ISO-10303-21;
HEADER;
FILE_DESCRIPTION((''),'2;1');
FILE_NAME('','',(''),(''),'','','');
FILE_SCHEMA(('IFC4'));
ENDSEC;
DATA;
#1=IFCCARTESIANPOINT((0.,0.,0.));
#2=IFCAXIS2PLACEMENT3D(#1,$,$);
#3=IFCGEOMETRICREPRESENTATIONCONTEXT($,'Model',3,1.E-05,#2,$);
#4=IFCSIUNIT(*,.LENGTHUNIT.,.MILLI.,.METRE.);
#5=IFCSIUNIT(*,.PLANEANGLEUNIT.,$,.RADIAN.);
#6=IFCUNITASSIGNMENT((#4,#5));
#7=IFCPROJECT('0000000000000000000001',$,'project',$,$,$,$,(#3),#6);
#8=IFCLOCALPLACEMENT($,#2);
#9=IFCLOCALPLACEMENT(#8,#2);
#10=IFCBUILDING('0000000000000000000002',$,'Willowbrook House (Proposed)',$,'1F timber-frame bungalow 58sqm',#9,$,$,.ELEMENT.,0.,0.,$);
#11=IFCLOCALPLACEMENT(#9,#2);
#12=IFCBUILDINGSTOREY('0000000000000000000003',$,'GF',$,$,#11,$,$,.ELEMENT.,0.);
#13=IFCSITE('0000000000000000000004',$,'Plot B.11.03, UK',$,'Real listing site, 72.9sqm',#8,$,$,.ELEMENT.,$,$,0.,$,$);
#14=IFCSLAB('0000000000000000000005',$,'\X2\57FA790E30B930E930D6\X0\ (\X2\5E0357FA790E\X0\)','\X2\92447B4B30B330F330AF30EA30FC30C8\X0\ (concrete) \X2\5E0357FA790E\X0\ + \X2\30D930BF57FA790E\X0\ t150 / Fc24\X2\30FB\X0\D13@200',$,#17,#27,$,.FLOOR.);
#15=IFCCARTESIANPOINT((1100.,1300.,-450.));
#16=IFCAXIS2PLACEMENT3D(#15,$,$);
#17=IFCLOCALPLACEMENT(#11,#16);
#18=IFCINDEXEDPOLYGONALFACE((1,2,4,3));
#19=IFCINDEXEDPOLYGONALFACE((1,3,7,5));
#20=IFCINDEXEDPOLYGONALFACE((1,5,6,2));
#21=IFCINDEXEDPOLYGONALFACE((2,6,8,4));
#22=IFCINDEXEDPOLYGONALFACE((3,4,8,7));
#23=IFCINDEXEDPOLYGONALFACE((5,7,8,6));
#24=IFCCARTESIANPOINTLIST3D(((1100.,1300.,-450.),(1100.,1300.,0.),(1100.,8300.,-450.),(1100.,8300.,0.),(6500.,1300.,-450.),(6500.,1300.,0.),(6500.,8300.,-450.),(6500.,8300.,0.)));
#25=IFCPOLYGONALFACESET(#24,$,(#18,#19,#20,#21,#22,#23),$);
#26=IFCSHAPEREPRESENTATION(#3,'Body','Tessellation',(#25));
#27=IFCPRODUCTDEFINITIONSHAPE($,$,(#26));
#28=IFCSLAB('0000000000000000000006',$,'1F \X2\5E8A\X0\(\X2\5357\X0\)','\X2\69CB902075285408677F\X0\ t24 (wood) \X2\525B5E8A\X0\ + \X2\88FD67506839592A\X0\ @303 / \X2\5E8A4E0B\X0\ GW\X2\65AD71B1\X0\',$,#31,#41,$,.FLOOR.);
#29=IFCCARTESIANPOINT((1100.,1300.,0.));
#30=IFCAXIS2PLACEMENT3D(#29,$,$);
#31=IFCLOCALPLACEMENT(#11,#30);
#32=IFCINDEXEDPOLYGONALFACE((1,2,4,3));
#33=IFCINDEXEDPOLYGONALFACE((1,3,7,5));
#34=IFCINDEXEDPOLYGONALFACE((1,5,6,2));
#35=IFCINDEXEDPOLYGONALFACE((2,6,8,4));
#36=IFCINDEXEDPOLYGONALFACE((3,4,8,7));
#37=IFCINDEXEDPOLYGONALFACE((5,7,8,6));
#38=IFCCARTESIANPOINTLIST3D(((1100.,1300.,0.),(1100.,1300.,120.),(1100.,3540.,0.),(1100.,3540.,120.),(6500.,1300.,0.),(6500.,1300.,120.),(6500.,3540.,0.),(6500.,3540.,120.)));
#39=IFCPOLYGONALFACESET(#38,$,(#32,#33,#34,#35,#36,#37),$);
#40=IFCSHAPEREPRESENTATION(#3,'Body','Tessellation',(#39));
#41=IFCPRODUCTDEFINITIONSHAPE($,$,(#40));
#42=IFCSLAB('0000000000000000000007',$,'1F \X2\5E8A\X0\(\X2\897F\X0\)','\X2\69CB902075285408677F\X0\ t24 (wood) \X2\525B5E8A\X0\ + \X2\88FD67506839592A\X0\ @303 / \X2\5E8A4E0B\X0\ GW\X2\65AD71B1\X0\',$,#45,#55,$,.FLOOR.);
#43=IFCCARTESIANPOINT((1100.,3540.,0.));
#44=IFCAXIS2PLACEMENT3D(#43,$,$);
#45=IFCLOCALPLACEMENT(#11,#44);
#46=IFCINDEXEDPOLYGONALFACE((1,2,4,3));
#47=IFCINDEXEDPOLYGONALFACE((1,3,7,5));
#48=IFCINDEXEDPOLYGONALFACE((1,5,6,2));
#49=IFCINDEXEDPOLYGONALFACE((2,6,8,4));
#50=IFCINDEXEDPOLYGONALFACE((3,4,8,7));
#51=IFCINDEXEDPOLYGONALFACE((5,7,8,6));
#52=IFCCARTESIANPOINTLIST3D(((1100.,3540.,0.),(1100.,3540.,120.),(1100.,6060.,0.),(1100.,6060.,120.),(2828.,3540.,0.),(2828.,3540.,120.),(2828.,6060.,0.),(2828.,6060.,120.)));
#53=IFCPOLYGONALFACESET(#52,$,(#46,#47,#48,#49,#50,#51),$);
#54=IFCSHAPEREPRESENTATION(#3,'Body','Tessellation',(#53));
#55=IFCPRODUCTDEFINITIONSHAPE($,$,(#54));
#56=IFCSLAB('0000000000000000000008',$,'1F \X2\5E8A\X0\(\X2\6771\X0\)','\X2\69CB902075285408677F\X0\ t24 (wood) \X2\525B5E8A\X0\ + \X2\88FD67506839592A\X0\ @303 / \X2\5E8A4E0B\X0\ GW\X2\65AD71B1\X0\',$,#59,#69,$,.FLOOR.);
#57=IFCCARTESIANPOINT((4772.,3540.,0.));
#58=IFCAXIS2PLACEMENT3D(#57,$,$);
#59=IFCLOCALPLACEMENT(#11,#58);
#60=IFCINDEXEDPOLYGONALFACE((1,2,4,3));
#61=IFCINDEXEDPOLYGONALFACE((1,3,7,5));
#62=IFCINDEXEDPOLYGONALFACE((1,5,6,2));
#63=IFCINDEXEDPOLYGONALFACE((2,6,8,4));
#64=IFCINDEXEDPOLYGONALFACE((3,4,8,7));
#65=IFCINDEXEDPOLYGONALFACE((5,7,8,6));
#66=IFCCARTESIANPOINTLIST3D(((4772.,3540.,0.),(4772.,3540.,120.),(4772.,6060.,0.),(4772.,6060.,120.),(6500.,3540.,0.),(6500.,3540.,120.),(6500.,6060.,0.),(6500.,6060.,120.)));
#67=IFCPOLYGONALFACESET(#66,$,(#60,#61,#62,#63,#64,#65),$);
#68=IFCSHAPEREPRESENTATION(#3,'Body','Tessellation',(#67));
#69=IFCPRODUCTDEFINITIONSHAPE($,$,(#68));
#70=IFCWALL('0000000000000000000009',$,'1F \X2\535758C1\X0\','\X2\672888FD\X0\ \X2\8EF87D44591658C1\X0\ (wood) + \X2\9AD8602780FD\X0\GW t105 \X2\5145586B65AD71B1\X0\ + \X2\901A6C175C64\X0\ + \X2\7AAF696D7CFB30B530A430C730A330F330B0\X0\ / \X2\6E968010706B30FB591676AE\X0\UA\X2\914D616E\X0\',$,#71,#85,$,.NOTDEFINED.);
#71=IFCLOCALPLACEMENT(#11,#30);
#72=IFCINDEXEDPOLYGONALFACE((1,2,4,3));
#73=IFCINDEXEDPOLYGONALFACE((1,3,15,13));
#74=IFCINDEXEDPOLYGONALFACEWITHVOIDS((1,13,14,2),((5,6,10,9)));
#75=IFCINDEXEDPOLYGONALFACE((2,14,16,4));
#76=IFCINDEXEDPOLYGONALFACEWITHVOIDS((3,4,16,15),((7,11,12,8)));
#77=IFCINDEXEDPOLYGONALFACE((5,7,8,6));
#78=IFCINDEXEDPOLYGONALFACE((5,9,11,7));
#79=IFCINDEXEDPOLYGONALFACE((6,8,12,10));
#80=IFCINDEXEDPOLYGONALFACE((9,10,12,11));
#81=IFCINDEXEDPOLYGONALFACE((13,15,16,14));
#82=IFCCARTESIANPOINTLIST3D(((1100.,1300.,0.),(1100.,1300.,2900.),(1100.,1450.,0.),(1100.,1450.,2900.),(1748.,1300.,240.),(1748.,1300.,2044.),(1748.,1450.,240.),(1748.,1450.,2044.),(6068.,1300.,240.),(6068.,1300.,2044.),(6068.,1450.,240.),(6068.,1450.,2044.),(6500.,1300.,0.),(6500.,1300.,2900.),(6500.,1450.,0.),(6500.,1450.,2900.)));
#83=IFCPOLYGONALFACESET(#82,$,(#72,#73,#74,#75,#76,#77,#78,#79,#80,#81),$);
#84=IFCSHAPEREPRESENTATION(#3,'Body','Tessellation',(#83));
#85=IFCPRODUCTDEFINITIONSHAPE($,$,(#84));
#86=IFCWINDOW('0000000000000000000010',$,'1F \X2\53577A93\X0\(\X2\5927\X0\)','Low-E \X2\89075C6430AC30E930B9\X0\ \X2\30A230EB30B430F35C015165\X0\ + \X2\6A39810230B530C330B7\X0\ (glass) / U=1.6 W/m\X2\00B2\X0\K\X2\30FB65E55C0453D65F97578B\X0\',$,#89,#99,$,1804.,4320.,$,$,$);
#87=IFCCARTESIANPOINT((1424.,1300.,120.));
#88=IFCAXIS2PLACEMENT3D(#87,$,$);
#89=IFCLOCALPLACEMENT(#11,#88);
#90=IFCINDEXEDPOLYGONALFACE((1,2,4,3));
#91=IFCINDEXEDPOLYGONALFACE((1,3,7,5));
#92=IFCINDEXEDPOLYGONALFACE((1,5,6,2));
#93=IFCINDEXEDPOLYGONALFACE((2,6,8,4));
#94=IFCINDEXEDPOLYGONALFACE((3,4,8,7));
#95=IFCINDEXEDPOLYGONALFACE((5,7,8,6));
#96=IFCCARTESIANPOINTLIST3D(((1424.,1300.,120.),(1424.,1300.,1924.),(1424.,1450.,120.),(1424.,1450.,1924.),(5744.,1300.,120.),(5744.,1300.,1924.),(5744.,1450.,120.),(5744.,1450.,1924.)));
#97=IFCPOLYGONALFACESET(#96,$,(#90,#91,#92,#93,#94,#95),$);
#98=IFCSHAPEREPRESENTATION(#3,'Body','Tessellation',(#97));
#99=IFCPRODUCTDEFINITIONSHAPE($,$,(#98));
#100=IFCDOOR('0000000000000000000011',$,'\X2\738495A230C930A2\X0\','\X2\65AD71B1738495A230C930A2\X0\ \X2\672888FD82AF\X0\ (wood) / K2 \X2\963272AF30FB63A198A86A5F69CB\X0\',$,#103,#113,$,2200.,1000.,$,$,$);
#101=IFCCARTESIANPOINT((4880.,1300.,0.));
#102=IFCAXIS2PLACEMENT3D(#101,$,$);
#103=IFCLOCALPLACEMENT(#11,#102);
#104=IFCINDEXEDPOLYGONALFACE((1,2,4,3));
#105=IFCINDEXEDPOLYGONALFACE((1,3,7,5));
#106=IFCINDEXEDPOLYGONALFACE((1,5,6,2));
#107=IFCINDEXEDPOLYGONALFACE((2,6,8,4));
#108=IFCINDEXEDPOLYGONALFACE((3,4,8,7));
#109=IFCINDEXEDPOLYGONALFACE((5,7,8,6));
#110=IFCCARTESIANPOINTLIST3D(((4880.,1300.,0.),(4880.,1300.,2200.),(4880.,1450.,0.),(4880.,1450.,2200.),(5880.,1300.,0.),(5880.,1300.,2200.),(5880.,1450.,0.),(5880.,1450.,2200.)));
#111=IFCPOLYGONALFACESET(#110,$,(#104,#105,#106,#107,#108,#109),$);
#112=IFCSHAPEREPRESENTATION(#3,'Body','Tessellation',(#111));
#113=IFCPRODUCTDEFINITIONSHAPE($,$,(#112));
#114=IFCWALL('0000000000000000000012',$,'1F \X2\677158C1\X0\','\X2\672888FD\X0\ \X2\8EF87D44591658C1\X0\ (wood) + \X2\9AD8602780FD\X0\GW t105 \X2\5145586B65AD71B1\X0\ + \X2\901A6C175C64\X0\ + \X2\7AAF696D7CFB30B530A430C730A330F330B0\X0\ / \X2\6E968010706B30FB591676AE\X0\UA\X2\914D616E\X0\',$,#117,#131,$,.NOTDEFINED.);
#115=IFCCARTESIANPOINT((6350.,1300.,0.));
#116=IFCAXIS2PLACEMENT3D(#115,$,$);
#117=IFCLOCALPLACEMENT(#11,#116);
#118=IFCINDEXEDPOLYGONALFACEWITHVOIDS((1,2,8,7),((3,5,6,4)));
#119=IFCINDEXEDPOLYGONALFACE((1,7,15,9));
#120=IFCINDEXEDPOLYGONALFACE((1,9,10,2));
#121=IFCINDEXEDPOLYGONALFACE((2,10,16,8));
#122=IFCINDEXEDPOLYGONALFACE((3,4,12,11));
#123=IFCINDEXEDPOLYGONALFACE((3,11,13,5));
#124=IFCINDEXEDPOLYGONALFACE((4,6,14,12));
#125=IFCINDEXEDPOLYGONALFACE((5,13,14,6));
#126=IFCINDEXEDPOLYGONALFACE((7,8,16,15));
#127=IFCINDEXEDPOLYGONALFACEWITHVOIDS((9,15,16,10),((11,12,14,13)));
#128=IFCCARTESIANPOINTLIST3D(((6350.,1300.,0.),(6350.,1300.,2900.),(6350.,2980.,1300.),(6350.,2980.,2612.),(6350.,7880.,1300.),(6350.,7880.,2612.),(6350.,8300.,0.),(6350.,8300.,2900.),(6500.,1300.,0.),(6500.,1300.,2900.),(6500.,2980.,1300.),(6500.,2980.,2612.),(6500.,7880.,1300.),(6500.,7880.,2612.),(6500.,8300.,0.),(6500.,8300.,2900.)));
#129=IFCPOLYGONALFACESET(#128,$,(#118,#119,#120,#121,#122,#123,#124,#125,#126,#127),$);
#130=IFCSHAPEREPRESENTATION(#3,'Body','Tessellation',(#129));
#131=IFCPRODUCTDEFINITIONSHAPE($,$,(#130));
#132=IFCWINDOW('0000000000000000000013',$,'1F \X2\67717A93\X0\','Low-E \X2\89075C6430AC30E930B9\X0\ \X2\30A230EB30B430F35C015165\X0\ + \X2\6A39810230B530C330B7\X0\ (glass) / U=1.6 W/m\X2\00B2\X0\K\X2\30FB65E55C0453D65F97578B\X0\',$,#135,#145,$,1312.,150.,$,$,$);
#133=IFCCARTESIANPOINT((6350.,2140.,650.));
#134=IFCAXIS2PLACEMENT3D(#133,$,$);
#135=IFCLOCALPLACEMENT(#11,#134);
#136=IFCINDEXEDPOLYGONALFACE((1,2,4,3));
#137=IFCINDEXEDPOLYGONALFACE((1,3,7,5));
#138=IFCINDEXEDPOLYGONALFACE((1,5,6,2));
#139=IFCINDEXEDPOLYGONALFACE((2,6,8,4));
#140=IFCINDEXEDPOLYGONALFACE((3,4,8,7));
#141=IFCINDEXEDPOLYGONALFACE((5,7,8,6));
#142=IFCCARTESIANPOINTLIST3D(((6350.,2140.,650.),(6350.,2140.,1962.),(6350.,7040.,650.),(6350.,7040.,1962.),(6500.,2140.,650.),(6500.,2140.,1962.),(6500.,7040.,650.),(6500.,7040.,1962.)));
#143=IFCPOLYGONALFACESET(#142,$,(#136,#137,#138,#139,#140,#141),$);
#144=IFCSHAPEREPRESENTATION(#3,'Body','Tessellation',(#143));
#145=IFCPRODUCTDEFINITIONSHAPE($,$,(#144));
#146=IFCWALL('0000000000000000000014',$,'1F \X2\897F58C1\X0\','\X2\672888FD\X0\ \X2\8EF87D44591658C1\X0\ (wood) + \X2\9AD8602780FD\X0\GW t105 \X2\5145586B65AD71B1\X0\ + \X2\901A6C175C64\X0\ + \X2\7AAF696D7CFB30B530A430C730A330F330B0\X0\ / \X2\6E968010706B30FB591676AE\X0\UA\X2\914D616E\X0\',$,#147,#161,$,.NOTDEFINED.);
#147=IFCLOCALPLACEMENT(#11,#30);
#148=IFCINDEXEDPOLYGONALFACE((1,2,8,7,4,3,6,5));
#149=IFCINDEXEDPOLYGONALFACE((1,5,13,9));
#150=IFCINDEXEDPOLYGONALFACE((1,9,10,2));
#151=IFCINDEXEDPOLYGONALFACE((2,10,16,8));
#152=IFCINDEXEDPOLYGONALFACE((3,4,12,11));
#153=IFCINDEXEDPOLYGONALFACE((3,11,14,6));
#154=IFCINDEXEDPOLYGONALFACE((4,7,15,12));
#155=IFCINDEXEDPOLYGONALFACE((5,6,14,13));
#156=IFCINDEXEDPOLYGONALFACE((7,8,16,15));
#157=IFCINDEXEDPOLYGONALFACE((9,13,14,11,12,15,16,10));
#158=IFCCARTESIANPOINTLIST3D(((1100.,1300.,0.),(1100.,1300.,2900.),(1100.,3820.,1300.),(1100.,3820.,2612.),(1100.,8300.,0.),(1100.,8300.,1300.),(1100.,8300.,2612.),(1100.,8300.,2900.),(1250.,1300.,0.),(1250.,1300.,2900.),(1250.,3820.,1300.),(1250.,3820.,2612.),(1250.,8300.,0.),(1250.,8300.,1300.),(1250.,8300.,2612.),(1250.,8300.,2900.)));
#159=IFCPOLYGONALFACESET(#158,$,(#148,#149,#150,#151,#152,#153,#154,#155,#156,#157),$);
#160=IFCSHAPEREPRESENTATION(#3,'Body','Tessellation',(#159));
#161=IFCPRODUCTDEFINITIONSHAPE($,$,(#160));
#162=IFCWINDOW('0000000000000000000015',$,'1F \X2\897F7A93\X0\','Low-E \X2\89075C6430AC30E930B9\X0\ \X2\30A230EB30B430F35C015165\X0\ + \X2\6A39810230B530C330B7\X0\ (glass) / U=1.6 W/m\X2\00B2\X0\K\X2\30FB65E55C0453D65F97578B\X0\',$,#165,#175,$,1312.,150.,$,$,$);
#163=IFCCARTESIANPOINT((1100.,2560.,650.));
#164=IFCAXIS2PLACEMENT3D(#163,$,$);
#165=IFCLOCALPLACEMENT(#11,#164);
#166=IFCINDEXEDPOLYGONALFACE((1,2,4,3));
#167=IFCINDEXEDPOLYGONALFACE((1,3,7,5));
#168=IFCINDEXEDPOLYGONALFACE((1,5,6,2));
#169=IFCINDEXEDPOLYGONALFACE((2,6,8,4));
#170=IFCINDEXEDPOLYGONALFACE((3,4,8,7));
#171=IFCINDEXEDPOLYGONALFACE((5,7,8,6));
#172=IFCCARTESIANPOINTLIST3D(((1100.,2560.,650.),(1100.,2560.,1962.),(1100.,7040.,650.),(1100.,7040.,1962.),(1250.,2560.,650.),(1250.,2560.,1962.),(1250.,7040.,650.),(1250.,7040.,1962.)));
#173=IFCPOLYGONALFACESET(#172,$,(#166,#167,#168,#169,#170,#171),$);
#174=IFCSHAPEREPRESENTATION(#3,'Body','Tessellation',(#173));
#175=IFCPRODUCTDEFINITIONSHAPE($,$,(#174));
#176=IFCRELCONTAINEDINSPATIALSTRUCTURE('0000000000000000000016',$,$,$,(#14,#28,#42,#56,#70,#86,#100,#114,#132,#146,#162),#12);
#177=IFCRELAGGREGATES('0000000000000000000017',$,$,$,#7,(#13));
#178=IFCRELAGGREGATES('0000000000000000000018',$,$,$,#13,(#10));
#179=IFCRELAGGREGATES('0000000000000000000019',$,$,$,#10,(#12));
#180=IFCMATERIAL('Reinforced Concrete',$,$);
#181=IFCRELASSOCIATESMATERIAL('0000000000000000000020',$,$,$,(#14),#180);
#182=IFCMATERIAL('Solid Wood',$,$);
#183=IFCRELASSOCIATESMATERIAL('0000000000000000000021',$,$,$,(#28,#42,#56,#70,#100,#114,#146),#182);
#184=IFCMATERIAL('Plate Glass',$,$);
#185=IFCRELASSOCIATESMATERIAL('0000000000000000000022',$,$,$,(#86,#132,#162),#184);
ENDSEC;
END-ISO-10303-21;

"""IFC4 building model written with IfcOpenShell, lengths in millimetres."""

from ifc_helpers import new_model, si_unit, frame, frame_2d, origin, place, context, project, spatial, rectangle, extrude, material, element, fill, save


model = new_model("IFC4")

# Units and contexts
model_context = context("Model", 3, precision=1e-05, world=origin())
ifc_project = project(units=[si_unit("LENGTHUNIT", "METRE", prefix="MILLI"), si_unit("PLANEANGLEUNIT", "RADIAN")], contexts=[model_context])

# Site, building, storey
site_placement = place(None, origin())
site = spatial("IfcSite", under=ifc_project, at=site_placement, Name="Plot B.11.03, UK", ObjectType="Real listing site, 72.9sqm", CompositionType="ELEMENT", RefElevation=0.0)
building_placement = place(site_placement, origin())
building = spatial("IfcBuilding", under=site, at=building_placement, Name="Willowbrook House (Proposed)", ObjectType="1F timber-frame bungalow 58sqm", CompositionType="ELEMENT", ElevationOfRefHeight=0.0, ElevationOfTerrain=0.0)
storey_placement = place(building_placement, origin())
storey = spatial("IfcBuildingStorey", under=building, at=storey_placement, Name="GF", CompositionType="ELEMENT", Elevation=0.0)

# Slabs
ifc_material_1 = material(Name="Reinforced Concrete")
slab_1_placement = place(storey_placement, frame((1100.0, 1300.0, -450.0)))
element("IfcSlab", 1, at=slab_1_placement, inside=storey, material=ifc_material_1, Name="基礎スラブ (布基礎)", Description="鉄筋コンクリート (concrete) 布基礎 + ベタ基礎 t150 / Fc24・D13@200", PredefinedType="FLOOR", context=model_context, shape_type="SweptSolid", body=[
    extrude(rectangle(XDim=5400.0, YDim=7000.0, at=frame_2d((2700.0, 3500.0))), frame((1100.0, 1300.0, -450.0)), (0.0, 0.0, 1.0), 450.0),
])
ifc_material_2 = material(Name="Solid Wood")
slab_2_placement = place(storey_placement, frame((1100.0, 1300.0, 0.0)))
element("IfcSlab", 2, at=slab_2_placement, inside=storey, material=ifc_material_2, Name="1F 床(南)", Description="構造用合板 t24 (wood) 剛床 + 製材根太 @303 / 床下 GW断熱", PredefinedType="FLOOR", context=model_context, shape_type="SweptSolid", body=[
    extrude(rectangle(XDim=5400.0, YDim=2240.0, at=frame_2d((2700.0, 1120.0))), frame((1100.0, 1300.0, 0.0)), (0.0, 0.0, 1.0), 120.0),
])
slab_3_placement = place(storey_placement, frame((1100.0, 3540.0, 0.0)))
element("IfcSlab", 3, at=slab_3_placement, inside=storey, material=ifc_material_2, Name="1F 床(西)", Description="構造用合板 t24 (wood) 剛床 + 製材根太 @303 / 床下 GW断熱", PredefinedType="FLOOR", context=model_context, shape_type="SweptSolid", body=[
    extrude(rectangle(XDim=1728.0, YDim=2520.0, at=frame_2d((864.0, 1260.0))), frame((1100.0, 3540.0, 0.0)), (0.0, 0.0, 1.0), 120.0),
])
slab_4_placement = place(storey_placement, frame((4772.0, 3540.0, 0.0)))
element("IfcSlab", 4, at=slab_4_placement, inside=storey, material=ifc_material_2, Name="1F 床(東)", Description="構造用合板 t24 (wood) 剛床 + 製材根太 @303 / 床下 GW断熱", PredefinedType="FLOOR", context=model_context, shape_type="SweptSolid", body=[
    extrude(rectangle(XDim=1728.0, YDim=2520.0, at=frame_2d((864.0, 1260.0))), frame((4772.0, 3540.0, 0.0)), (0.0, 0.0, 1.0), 120.0),
])

# Wall, openings, window, door
wall_1_placement = place(storey_placement, frame((1100.0, 1300.0, 0.0)))
wall_1 = element("IfcWall", 5, at=wall_1_placement, inside=storey, material=ifc_material_2, Name="1F 南壁", Description="木製 軸組外壁 (wood) + 高性能GW t105 充填断熱 + 通気層 + 窯業系サイディング / 準耐火・外皮UA配慮", PredefinedType="NOTDEFINED", context=model_context, shape_type="SweptSolid", body=[
    extrude(rectangle(XDim=5400.0, YDim=150.0, at=frame_2d((2700.0, 75.0))), frame((1100.0, 1300.0, 0.0)), (0.0, 0.0, 1.0), 2900.0),
])
opening_1_placement = place(storey_placement, frame((1424.0, 1300.0, 120.0)))
opening_1 = element("IfcOpeningElement", 6, at=opening_1_placement, cuts=wall_1, PredefinedType="NOTDEFINED", context=model_context, shape_type="SweptSolid", body=[
    extrude(rectangle(XDim=4320.0, YDim=150.0, at=frame_2d((2160.0, 75.0))), frame((1424.0, 1300.0, 120.0)), (0.0, 0.0, 1.0), 1804.0),
])
opening_2_placement = place(storey_placement, frame((4880.0, 1300.0, 0.0)))
opening_2 = element("IfcOpeningElement", 7, at=opening_2_placement, cuts=wall_1, PredefinedType="NOTDEFINED", context=model_context, shape_type="SweptSolid", body=[
    extrude(rectangle(XDim=1000.0, YDim=150.0, at=frame_2d((500.0, 75.0))), frame((4880.0, 1300.0, 0.0)), (0.0, 0.0, 1.0), 2200.0),
])
ifc_material_3 = material(Name="Plate Glass")
window_1_placement = place(storey_placement, frame((1424.0, 1300.0, 120.0)))
window_1 = element("IfcWindow", 8, at=window_1_placement, inside=storey, material=ifc_material_3, Name="1F 南窓(大)", Description="Low-E 複層ガラス アルゴン封入 + 樹脂サッシ (glass) / U=1.6 W/m²K・日射取得型", OverallHeight=1804.0, OverallWidth=4320.0, context=model_context, shape_type="SweptSolid", body=[
    extrude(rectangle(XDim=4320.0, YDim=150.0, at=frame_2d((2160.0, 75.0))), frame((1424.0, 1300.0, 120.0)), (0.0, 0.0, 1.0), 1804.0),
])
fill(opening_1, window_1)
door_placement = place(storey_placement, frame((4880.0, 1300.0, 0.0)))
door = element("IfcDoor", 9, at=door_placement, inside=storey, material=ifc_material_2, Name="玄関ドア", Description="断熱玄関ドア 木製芯 (wood) / K2 防犯・採風機構", OverallHeight=2200.0, OverallWidth=1000.0, context=model_context, shape_type="SweptSolid", body=[
    extrude(rectangle(XDim=1000.0, YDim=150.0, at=frame_2d((500.0, 75.0))), frame((4880.0, 1300.0, 0.0)), (0.0, 0.0, 1.0), 2200.0),
])
fill(opening_2, door)

# Walls, openings, windows
wall_2_placement = place(storey_placement, frame((6350.0, 1300.0, 0.0)))
wall_2 = element("IfcWall", 10, at=wall_2_placement, inside=storey, material=ifc_material_2, Name="1F 東壁", Description="木製 軸組外壁 (wood) + 高性能GW t105 充填断熱 + 通気層 + 窯業系サイディング / 準耐火・外皮UA配慮", PredefinedType="NOTDEFINED", context=model_context, shape_type="SweptSolid", body=[
    extrude(rectangle(XDim=150.0, YDim=7000.0, at=frame_2d((75.0, 3500.0))), frame((6350.0, 1300.0, 0.0)), (0.0, 0.0, 1.0), 2900.0),
])
opening_3_placement = place(storey_placement, frame((6350.0, 2140.0, 650.0)))
opening_3 = element("IfcOpeningElement", 11, at=opening_3_placement, cuts=wall_2, PredefinedType="NOTDEFINED", context=model_context, shape_type="SweptSolid", body=[
    extrude(rectangle(XDim=150.0, YDim=4900.0, at=frame_2d((75.0, 2450.0))), frame((6350.0, 2140.0, 650.0)), (0.0, 0.0, 1.0), 1312.0),
])
window_2_placement = place(storey_placement, frame((6350.0, 2140.0, 650.0)))
window_2 = element("IfcWindow", 12, at=window_2_placement, inside=storey, material=ifc_material_3, Name="1F 東窓", Description="Low-E 複層ガラス アルゴン封入 + 樹脂サッシ (glass) / U=1.6 W/m²K・日射取得型", OverallHeight=1312.0, OverallWidth=150.0, context=model_context, shape_type="SweptSolid", body=[
    extrude(rectangle(XDim=150.0, YDim=4900.0, at=frame_2d((75.0, 2450.0))), frame((6350.0, 2140.0, 650.0)), (0.0, 0.0, 1.0), 1312.0),
])
fill(opening_3, window_2)
wall_3_placement = place(storey_placement, frame((1100.0, 1300.0, 0.0)))
wall_3 = element("IfcWall", 13, at=wall_3_placement, inside=storey, material=ifc_material_2, Name="1F 西壁", Description="木製 軸組外壁 (wood) + 高性能GW t105 充填断熱 + 通気層 + 窯業系サイディング / 準耐火・外皮UA配慮", PredefinedType="NOTDEFINED", context=model_context, shape_type="SweptSolid", body=[
    extrude(rectangle(XDim=150.0, YDim=7000.0, at=frame_2d((75.0, 3500.0))), frame((1100.0, 1300.0, 0.0)), (0.0, 0.0, 1.0), 2900.0),
])
opening_4_placement = place(storey_placement, frame((1100.0, 2560.0, 650.0)))
opening_4 = element("IfcOpeningElement", 14, at=opening_4_placement, cuts=wall_3, PredefinedType="NOTDEFINED", context=model_context, shape_type="SweptSolid", body=[
    extrude(rectangle(XDim=150.0, YDim=4480.0, at=frame_2d((75.0, 2240.0))), frame((1100.0, 2560.0, 650.0)), (0.0, 0.0, 1.0), 1312.0),
])
window_3_placement = place(storey_placement, frame((1100.0, 2560.0, 650.0)))
window_3 = element("IfcWindow", 15, at=window_3_placement, inside=storey, material=ifc_material_3, Name="1F 西窓", Description="Low-E 複層ガラス アルゴン封入 + 樹脂サッシ (glass) / U=1.6 W/m²K・日射取得型", OverallHeight=1312.0, OverallWidth=150.0, context=model_context, shape_type="SweptSolid", body=[
    extrude(rectangle(XDim=150.0, YDim=4480.0, at=frame_2d((75.0, 2240.0))), frame((1100.0, 2560.0, 650.0)), (0.0, 0.0, 1.0), 1312.0),
])
fill(opening_4, window_3)

save(model, "model.ifc")
